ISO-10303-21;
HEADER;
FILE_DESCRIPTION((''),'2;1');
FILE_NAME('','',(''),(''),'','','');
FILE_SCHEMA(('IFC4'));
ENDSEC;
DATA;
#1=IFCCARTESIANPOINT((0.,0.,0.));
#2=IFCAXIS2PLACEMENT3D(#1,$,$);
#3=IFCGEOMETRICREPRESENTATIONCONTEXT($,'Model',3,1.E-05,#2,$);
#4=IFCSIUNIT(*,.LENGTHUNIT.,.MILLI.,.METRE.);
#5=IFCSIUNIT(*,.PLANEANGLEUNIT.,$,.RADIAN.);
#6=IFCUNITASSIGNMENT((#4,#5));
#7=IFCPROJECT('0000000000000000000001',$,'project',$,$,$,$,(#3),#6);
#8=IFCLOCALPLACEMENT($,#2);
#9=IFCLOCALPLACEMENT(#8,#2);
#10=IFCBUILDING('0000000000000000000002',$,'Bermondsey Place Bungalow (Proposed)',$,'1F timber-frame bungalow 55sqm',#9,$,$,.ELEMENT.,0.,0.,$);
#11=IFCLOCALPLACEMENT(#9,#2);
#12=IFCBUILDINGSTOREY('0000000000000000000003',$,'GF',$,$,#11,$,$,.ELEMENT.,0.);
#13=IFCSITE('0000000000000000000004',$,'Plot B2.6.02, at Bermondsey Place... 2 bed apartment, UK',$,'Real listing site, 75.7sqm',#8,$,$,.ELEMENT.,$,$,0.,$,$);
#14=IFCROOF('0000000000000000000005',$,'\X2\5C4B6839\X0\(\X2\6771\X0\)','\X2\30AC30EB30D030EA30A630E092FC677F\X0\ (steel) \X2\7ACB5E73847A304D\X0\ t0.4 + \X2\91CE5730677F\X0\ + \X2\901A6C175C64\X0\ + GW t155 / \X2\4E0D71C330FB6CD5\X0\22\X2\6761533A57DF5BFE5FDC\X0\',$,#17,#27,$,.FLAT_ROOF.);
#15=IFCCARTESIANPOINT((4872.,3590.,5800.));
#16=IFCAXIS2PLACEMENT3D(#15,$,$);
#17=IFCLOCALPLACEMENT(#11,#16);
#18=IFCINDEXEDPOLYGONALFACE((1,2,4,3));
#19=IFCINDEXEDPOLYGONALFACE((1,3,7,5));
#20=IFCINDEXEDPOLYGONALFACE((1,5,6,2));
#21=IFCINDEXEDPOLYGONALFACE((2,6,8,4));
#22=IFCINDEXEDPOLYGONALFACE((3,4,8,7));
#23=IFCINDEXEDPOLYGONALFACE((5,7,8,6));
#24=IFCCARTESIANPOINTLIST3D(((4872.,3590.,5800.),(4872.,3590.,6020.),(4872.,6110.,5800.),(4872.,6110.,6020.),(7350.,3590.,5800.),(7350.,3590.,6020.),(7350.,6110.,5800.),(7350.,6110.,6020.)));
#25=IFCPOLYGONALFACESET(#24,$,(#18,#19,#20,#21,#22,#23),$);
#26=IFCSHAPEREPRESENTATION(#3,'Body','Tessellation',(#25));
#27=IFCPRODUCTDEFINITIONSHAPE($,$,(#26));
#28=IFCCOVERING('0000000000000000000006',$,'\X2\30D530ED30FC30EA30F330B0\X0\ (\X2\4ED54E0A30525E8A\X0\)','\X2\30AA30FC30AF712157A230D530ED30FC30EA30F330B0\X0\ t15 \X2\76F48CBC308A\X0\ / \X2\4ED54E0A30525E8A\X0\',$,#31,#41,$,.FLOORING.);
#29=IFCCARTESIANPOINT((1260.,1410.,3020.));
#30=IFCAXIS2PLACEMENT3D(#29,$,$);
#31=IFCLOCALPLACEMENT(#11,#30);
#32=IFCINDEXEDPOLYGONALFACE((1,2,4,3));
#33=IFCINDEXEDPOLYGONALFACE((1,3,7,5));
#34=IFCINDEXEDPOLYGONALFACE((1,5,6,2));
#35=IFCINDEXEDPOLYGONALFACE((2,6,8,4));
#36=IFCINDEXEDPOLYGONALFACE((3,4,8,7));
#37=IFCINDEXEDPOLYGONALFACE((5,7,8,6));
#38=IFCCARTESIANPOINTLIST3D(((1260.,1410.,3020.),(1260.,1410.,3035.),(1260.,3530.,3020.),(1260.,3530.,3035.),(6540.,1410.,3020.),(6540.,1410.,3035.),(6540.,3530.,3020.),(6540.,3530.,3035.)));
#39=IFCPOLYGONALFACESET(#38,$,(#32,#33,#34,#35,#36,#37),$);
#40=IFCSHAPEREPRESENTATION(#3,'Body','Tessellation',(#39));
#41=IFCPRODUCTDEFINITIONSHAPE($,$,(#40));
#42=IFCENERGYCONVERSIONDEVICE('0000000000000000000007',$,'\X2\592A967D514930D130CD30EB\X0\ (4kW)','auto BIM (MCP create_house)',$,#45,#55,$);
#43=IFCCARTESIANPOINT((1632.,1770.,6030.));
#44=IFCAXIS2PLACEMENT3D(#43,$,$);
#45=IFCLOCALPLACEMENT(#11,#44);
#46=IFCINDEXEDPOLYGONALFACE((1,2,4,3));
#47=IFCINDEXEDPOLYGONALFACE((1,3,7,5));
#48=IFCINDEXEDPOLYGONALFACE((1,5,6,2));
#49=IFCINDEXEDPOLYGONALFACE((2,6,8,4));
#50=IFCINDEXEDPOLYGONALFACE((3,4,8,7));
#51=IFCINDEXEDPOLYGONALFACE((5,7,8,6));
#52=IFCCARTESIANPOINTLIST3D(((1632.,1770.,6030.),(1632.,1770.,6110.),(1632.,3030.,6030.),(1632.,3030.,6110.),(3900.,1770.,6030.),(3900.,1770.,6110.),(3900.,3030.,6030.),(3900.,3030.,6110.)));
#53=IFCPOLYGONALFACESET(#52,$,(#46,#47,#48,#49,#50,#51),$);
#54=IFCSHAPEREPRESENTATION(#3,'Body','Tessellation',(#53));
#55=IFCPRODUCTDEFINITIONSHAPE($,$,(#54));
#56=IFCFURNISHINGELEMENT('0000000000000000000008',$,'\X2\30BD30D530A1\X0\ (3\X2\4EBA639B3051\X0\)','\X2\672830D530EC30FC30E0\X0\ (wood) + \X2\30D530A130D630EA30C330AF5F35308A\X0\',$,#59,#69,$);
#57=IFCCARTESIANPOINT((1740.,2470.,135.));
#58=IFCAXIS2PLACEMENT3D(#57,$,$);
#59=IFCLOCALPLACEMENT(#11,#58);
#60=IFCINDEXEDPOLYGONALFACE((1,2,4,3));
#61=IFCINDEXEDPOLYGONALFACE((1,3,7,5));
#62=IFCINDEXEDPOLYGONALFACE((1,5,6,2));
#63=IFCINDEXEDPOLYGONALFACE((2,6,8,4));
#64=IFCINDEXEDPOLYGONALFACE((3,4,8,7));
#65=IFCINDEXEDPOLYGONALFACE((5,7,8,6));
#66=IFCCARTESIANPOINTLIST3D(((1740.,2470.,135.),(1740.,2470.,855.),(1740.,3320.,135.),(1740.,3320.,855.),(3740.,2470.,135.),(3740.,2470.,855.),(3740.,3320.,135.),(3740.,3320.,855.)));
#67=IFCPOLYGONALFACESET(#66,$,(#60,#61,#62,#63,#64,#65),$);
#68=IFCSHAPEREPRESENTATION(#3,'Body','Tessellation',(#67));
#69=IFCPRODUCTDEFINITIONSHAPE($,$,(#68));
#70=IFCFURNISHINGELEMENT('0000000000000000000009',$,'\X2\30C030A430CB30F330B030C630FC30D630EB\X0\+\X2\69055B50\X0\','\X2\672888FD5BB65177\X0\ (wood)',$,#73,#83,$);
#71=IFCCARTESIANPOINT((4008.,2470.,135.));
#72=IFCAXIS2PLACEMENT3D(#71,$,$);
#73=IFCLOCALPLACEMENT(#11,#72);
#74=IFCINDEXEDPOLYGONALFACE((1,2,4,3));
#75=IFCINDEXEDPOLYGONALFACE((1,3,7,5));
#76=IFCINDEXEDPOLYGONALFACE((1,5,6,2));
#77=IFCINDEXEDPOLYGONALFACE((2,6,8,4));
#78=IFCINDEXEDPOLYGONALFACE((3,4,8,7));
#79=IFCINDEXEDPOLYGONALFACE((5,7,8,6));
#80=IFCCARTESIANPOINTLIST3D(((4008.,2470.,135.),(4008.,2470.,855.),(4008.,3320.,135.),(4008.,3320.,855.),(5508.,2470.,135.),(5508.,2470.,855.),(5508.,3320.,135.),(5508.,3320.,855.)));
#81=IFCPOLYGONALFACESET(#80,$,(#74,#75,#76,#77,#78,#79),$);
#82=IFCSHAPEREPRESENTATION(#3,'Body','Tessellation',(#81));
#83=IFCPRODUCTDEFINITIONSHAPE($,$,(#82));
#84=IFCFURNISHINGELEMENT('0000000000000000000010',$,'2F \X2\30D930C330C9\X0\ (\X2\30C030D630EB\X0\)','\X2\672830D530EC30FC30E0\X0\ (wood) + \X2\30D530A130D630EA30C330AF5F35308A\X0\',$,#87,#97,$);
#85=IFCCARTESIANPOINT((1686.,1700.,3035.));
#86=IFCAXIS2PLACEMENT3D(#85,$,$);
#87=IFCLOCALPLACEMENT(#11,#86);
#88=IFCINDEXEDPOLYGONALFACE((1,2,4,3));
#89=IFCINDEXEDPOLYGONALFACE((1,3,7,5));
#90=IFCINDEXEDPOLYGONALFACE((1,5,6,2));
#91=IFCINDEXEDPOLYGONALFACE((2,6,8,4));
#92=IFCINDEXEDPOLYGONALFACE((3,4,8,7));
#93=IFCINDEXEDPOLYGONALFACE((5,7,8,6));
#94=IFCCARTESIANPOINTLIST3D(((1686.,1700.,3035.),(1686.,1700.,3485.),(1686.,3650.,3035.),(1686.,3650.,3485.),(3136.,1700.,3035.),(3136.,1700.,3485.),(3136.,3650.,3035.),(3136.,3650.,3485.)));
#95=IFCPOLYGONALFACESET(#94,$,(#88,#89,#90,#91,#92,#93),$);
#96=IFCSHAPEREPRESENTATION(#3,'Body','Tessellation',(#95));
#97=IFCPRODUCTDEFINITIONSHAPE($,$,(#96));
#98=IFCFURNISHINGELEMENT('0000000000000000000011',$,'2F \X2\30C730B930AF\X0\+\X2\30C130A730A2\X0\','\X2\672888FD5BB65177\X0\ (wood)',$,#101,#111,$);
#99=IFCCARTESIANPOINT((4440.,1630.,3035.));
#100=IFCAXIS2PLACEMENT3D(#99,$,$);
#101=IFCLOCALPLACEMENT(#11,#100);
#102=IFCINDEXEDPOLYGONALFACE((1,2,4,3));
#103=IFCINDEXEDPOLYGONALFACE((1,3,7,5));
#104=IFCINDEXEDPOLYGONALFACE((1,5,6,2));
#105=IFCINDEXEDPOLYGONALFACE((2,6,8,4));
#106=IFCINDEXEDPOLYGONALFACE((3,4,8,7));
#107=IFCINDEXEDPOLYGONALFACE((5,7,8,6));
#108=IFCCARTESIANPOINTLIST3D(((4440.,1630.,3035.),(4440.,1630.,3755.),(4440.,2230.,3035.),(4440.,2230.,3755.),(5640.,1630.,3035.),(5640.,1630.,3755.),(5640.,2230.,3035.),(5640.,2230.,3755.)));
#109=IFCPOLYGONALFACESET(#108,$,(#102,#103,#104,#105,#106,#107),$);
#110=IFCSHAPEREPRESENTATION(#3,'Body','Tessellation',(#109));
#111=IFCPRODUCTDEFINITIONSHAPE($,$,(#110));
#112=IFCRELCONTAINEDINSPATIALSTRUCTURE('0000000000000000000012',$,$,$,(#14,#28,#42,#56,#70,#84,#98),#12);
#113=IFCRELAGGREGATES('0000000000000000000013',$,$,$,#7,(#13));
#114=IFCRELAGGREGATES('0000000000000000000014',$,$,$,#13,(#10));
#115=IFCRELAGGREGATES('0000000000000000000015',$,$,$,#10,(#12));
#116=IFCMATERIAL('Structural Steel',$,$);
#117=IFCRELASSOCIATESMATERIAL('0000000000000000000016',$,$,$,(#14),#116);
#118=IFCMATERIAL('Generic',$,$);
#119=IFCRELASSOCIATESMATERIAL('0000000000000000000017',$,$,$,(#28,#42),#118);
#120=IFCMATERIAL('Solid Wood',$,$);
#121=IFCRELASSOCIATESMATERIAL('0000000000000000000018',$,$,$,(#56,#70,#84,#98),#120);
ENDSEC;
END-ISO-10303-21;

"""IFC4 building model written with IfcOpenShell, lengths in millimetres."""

from ifc_helpers import new_model, si_unit, frame, frame_2d, origin, place, context, project, spatial, rectangle, extrude, material, element, save


model = new_model("IFC4")

# Units and contexts
model_context = context("Model", 3, precision=1e-05, world=origin())
ifc_project = project(units=[si_unit("LENGTHUNIT", "METRE", prefix="MILLI"), si_unit("PLANEANGLEUNIT", "RADIAN")], contexts=[model_context])

# Site, building, storey
site_placement = place(None, origin())
site = spatial("IfcSite", under=ifc_project, at=site_placement, Name="Plot B2.6.02, at Bermondsey Place... 2 bed apartment, UK", ObjectType="Real listing site, 75.7sqm", CompositionType="ELEMENT", RefElevation=0.0)
building_placement = place(site_placement, origin())
building = spatial("IfcBuilding", under=site, at=building_placement, Name="Bermondsey Place Bungalow (Proposed)", ObjectType="1F timber-frame bungalow 55sqm", CompositionType="ELEMENT", ElevationOfRefHeight=0.0, ElevationOfTerrain=0.0)
storey_placement = place(building_placement, origin())
storey = spatial("IfcBuildingStorey", under=building, at=storey_placement, Name="GF", CompositionType="ELEMENT", Elevation=0.0)

# Shared definitions
ifc_material_1 = material(Name="Solid Wood")

# Roof
ifc_material_2 = material(Name="Structural Steel")
roof_1_placement = place(storey_placement, frame((4872.0, 3590.0, 5800.0)))
element("IfcRoof", 1, at=roof_1_placement, inside=storey, material=ifc_material_2, Name="屋根(東)", Description="ガルバリウム鋼板 (steel) 立平葺き t0.4 + 野地板 + 通気層 + GW t155 / 不燃・法22条区域対応", PredefinedType="FLAT_ROOF", context=model_context, shape_type="SweptSolid", body=[
    extrude(rectangle(XDim=2478.0, YDim=2520.0, at=frame_2d((1239.0, 1260.0))), frame((4872.0, 3590.0, 5800.0)), (0.0, 0.0, 1.0), 220.0),
])

# Covering
ifc_material_3 = material(Name="Generic")
covering_placement = place(storey_placement, frame((1260.0, 1410.0, 3020.0)))
element("IfcCovering", 2, at=covering_placement, inside=storey, material=ifc_material_3, Name="フローリング (仕上げ床)", Description="オーク無垢フローリング t15 直貼り / 仕上げ床", PredefinedType="FLOORING", context=model_context, shape_type="SweptSolid", body=[
    extrude(rectangle(XDim=5280.0, YDim=2120.0, at=frame_2d((2640.0, 1060.0))), frame((1260.0, 1410.0, 3020.0)), (0.0, 0.0, 1.0), 15.0),
])

# Energy conversion device
energy_conversion_device_placement = place(storey_placement, frame((1632.0, 1770.0, 6030.0)))
element("IfcEnergyConversionDevice", 3, at=energy_conversion_device_placement, inside=storey, material=ifc_material_3, Name="太陽光パネル (4kW)", Description="auto BIM (MCP create_house)", context=model_context, shape_type="SweptSolid", body=[
    extrude(rectangle(XDim=2268.0, YDim=1260.0, at=frame_2d((1134.0, 630.0))), frame((1632.0, 1770.0, 6030.0)), (0.0, 0.0, 1.0), 80.0),
])

# Furnishing elements
furnishing_1_placement = place(storey_placement, frame((1740.0, 2470.0, 135.0)))
element("IfcFurnishingElement", 4, at=furnishing_1_placement, inside=storey, material=ifc_material_1, Name="ソファ (3人掛け)", Description="木フレーム (wood) + ファブリック張り", context=model_context, shape_type="SweptSolid", body=[
    extrude(rectangle(XDim=2000.0, YDim=850.0, at=frame_2d((1000.0, 425.0))), frame((1740.0, 2470.0, 135.0)), (0.0, 0.0, 1.0), 720.0),
])
furnishing_2_placement = place(storey_placement, frame((4008.0, 2470.0, 135.0)))
element("IfcFurnishingElement", 5, at=furnishing_2_placement, inside=storey, material=ifc_material_1, Name="ダイニングテーブル+椅子", Description="木製家具 (wood)", context=model_context, shape_type="SweptSolid", body=[
    extrude(rectangle(XDim=1500.0, YDim=850.0, at=frame_2d((750.0, 425.0))), frame((4008.0, 2470.0, 135.0)), (0.0, 0.0, 1.0), 720.0),
])
furnishing_3_placement = place(storey_placement, frame((1686.0, 1700.0, 3035.0)))
element("IfcFurnishingElement", 6, at=furnishing_3_placement, inside=storey, material=ifc_material_1, Name="2F ベッド (ダブル)", Description="木フレーム (wood) + ファブリック張り", context=model_context, shape_type="SweptSolid", body=[
    extrude(rectangle(XDim=1450.0, YDim=1950.0, at=frame_2d((725.0, 975.0))), frame((1686.0, 1700.0, 3035.0)), (0.0, 0.0, 1.0), 450.0),
])
furnishing_4_placement = place(storey_placement, frame((4440.0, 1630.0, 3035.0)))
element("IfcFurnishingElement", 7, at=furnishing_4_placement, inside=storey, material=ifc_material_1, Name="2F デスク+チェア", Description="木製家具 (wood)", context=model_context, shape_type="SweptSolid", body=[
    extrude(rectangle(XDim=1200.0, YDim=600.0, at=frame_2d((600.0, 300.0))), frame((4440.0, 1630.0, 3035.0)), (0.0, 0.0, 1.0), 720.0),
])

save(model, "model.ifc")
